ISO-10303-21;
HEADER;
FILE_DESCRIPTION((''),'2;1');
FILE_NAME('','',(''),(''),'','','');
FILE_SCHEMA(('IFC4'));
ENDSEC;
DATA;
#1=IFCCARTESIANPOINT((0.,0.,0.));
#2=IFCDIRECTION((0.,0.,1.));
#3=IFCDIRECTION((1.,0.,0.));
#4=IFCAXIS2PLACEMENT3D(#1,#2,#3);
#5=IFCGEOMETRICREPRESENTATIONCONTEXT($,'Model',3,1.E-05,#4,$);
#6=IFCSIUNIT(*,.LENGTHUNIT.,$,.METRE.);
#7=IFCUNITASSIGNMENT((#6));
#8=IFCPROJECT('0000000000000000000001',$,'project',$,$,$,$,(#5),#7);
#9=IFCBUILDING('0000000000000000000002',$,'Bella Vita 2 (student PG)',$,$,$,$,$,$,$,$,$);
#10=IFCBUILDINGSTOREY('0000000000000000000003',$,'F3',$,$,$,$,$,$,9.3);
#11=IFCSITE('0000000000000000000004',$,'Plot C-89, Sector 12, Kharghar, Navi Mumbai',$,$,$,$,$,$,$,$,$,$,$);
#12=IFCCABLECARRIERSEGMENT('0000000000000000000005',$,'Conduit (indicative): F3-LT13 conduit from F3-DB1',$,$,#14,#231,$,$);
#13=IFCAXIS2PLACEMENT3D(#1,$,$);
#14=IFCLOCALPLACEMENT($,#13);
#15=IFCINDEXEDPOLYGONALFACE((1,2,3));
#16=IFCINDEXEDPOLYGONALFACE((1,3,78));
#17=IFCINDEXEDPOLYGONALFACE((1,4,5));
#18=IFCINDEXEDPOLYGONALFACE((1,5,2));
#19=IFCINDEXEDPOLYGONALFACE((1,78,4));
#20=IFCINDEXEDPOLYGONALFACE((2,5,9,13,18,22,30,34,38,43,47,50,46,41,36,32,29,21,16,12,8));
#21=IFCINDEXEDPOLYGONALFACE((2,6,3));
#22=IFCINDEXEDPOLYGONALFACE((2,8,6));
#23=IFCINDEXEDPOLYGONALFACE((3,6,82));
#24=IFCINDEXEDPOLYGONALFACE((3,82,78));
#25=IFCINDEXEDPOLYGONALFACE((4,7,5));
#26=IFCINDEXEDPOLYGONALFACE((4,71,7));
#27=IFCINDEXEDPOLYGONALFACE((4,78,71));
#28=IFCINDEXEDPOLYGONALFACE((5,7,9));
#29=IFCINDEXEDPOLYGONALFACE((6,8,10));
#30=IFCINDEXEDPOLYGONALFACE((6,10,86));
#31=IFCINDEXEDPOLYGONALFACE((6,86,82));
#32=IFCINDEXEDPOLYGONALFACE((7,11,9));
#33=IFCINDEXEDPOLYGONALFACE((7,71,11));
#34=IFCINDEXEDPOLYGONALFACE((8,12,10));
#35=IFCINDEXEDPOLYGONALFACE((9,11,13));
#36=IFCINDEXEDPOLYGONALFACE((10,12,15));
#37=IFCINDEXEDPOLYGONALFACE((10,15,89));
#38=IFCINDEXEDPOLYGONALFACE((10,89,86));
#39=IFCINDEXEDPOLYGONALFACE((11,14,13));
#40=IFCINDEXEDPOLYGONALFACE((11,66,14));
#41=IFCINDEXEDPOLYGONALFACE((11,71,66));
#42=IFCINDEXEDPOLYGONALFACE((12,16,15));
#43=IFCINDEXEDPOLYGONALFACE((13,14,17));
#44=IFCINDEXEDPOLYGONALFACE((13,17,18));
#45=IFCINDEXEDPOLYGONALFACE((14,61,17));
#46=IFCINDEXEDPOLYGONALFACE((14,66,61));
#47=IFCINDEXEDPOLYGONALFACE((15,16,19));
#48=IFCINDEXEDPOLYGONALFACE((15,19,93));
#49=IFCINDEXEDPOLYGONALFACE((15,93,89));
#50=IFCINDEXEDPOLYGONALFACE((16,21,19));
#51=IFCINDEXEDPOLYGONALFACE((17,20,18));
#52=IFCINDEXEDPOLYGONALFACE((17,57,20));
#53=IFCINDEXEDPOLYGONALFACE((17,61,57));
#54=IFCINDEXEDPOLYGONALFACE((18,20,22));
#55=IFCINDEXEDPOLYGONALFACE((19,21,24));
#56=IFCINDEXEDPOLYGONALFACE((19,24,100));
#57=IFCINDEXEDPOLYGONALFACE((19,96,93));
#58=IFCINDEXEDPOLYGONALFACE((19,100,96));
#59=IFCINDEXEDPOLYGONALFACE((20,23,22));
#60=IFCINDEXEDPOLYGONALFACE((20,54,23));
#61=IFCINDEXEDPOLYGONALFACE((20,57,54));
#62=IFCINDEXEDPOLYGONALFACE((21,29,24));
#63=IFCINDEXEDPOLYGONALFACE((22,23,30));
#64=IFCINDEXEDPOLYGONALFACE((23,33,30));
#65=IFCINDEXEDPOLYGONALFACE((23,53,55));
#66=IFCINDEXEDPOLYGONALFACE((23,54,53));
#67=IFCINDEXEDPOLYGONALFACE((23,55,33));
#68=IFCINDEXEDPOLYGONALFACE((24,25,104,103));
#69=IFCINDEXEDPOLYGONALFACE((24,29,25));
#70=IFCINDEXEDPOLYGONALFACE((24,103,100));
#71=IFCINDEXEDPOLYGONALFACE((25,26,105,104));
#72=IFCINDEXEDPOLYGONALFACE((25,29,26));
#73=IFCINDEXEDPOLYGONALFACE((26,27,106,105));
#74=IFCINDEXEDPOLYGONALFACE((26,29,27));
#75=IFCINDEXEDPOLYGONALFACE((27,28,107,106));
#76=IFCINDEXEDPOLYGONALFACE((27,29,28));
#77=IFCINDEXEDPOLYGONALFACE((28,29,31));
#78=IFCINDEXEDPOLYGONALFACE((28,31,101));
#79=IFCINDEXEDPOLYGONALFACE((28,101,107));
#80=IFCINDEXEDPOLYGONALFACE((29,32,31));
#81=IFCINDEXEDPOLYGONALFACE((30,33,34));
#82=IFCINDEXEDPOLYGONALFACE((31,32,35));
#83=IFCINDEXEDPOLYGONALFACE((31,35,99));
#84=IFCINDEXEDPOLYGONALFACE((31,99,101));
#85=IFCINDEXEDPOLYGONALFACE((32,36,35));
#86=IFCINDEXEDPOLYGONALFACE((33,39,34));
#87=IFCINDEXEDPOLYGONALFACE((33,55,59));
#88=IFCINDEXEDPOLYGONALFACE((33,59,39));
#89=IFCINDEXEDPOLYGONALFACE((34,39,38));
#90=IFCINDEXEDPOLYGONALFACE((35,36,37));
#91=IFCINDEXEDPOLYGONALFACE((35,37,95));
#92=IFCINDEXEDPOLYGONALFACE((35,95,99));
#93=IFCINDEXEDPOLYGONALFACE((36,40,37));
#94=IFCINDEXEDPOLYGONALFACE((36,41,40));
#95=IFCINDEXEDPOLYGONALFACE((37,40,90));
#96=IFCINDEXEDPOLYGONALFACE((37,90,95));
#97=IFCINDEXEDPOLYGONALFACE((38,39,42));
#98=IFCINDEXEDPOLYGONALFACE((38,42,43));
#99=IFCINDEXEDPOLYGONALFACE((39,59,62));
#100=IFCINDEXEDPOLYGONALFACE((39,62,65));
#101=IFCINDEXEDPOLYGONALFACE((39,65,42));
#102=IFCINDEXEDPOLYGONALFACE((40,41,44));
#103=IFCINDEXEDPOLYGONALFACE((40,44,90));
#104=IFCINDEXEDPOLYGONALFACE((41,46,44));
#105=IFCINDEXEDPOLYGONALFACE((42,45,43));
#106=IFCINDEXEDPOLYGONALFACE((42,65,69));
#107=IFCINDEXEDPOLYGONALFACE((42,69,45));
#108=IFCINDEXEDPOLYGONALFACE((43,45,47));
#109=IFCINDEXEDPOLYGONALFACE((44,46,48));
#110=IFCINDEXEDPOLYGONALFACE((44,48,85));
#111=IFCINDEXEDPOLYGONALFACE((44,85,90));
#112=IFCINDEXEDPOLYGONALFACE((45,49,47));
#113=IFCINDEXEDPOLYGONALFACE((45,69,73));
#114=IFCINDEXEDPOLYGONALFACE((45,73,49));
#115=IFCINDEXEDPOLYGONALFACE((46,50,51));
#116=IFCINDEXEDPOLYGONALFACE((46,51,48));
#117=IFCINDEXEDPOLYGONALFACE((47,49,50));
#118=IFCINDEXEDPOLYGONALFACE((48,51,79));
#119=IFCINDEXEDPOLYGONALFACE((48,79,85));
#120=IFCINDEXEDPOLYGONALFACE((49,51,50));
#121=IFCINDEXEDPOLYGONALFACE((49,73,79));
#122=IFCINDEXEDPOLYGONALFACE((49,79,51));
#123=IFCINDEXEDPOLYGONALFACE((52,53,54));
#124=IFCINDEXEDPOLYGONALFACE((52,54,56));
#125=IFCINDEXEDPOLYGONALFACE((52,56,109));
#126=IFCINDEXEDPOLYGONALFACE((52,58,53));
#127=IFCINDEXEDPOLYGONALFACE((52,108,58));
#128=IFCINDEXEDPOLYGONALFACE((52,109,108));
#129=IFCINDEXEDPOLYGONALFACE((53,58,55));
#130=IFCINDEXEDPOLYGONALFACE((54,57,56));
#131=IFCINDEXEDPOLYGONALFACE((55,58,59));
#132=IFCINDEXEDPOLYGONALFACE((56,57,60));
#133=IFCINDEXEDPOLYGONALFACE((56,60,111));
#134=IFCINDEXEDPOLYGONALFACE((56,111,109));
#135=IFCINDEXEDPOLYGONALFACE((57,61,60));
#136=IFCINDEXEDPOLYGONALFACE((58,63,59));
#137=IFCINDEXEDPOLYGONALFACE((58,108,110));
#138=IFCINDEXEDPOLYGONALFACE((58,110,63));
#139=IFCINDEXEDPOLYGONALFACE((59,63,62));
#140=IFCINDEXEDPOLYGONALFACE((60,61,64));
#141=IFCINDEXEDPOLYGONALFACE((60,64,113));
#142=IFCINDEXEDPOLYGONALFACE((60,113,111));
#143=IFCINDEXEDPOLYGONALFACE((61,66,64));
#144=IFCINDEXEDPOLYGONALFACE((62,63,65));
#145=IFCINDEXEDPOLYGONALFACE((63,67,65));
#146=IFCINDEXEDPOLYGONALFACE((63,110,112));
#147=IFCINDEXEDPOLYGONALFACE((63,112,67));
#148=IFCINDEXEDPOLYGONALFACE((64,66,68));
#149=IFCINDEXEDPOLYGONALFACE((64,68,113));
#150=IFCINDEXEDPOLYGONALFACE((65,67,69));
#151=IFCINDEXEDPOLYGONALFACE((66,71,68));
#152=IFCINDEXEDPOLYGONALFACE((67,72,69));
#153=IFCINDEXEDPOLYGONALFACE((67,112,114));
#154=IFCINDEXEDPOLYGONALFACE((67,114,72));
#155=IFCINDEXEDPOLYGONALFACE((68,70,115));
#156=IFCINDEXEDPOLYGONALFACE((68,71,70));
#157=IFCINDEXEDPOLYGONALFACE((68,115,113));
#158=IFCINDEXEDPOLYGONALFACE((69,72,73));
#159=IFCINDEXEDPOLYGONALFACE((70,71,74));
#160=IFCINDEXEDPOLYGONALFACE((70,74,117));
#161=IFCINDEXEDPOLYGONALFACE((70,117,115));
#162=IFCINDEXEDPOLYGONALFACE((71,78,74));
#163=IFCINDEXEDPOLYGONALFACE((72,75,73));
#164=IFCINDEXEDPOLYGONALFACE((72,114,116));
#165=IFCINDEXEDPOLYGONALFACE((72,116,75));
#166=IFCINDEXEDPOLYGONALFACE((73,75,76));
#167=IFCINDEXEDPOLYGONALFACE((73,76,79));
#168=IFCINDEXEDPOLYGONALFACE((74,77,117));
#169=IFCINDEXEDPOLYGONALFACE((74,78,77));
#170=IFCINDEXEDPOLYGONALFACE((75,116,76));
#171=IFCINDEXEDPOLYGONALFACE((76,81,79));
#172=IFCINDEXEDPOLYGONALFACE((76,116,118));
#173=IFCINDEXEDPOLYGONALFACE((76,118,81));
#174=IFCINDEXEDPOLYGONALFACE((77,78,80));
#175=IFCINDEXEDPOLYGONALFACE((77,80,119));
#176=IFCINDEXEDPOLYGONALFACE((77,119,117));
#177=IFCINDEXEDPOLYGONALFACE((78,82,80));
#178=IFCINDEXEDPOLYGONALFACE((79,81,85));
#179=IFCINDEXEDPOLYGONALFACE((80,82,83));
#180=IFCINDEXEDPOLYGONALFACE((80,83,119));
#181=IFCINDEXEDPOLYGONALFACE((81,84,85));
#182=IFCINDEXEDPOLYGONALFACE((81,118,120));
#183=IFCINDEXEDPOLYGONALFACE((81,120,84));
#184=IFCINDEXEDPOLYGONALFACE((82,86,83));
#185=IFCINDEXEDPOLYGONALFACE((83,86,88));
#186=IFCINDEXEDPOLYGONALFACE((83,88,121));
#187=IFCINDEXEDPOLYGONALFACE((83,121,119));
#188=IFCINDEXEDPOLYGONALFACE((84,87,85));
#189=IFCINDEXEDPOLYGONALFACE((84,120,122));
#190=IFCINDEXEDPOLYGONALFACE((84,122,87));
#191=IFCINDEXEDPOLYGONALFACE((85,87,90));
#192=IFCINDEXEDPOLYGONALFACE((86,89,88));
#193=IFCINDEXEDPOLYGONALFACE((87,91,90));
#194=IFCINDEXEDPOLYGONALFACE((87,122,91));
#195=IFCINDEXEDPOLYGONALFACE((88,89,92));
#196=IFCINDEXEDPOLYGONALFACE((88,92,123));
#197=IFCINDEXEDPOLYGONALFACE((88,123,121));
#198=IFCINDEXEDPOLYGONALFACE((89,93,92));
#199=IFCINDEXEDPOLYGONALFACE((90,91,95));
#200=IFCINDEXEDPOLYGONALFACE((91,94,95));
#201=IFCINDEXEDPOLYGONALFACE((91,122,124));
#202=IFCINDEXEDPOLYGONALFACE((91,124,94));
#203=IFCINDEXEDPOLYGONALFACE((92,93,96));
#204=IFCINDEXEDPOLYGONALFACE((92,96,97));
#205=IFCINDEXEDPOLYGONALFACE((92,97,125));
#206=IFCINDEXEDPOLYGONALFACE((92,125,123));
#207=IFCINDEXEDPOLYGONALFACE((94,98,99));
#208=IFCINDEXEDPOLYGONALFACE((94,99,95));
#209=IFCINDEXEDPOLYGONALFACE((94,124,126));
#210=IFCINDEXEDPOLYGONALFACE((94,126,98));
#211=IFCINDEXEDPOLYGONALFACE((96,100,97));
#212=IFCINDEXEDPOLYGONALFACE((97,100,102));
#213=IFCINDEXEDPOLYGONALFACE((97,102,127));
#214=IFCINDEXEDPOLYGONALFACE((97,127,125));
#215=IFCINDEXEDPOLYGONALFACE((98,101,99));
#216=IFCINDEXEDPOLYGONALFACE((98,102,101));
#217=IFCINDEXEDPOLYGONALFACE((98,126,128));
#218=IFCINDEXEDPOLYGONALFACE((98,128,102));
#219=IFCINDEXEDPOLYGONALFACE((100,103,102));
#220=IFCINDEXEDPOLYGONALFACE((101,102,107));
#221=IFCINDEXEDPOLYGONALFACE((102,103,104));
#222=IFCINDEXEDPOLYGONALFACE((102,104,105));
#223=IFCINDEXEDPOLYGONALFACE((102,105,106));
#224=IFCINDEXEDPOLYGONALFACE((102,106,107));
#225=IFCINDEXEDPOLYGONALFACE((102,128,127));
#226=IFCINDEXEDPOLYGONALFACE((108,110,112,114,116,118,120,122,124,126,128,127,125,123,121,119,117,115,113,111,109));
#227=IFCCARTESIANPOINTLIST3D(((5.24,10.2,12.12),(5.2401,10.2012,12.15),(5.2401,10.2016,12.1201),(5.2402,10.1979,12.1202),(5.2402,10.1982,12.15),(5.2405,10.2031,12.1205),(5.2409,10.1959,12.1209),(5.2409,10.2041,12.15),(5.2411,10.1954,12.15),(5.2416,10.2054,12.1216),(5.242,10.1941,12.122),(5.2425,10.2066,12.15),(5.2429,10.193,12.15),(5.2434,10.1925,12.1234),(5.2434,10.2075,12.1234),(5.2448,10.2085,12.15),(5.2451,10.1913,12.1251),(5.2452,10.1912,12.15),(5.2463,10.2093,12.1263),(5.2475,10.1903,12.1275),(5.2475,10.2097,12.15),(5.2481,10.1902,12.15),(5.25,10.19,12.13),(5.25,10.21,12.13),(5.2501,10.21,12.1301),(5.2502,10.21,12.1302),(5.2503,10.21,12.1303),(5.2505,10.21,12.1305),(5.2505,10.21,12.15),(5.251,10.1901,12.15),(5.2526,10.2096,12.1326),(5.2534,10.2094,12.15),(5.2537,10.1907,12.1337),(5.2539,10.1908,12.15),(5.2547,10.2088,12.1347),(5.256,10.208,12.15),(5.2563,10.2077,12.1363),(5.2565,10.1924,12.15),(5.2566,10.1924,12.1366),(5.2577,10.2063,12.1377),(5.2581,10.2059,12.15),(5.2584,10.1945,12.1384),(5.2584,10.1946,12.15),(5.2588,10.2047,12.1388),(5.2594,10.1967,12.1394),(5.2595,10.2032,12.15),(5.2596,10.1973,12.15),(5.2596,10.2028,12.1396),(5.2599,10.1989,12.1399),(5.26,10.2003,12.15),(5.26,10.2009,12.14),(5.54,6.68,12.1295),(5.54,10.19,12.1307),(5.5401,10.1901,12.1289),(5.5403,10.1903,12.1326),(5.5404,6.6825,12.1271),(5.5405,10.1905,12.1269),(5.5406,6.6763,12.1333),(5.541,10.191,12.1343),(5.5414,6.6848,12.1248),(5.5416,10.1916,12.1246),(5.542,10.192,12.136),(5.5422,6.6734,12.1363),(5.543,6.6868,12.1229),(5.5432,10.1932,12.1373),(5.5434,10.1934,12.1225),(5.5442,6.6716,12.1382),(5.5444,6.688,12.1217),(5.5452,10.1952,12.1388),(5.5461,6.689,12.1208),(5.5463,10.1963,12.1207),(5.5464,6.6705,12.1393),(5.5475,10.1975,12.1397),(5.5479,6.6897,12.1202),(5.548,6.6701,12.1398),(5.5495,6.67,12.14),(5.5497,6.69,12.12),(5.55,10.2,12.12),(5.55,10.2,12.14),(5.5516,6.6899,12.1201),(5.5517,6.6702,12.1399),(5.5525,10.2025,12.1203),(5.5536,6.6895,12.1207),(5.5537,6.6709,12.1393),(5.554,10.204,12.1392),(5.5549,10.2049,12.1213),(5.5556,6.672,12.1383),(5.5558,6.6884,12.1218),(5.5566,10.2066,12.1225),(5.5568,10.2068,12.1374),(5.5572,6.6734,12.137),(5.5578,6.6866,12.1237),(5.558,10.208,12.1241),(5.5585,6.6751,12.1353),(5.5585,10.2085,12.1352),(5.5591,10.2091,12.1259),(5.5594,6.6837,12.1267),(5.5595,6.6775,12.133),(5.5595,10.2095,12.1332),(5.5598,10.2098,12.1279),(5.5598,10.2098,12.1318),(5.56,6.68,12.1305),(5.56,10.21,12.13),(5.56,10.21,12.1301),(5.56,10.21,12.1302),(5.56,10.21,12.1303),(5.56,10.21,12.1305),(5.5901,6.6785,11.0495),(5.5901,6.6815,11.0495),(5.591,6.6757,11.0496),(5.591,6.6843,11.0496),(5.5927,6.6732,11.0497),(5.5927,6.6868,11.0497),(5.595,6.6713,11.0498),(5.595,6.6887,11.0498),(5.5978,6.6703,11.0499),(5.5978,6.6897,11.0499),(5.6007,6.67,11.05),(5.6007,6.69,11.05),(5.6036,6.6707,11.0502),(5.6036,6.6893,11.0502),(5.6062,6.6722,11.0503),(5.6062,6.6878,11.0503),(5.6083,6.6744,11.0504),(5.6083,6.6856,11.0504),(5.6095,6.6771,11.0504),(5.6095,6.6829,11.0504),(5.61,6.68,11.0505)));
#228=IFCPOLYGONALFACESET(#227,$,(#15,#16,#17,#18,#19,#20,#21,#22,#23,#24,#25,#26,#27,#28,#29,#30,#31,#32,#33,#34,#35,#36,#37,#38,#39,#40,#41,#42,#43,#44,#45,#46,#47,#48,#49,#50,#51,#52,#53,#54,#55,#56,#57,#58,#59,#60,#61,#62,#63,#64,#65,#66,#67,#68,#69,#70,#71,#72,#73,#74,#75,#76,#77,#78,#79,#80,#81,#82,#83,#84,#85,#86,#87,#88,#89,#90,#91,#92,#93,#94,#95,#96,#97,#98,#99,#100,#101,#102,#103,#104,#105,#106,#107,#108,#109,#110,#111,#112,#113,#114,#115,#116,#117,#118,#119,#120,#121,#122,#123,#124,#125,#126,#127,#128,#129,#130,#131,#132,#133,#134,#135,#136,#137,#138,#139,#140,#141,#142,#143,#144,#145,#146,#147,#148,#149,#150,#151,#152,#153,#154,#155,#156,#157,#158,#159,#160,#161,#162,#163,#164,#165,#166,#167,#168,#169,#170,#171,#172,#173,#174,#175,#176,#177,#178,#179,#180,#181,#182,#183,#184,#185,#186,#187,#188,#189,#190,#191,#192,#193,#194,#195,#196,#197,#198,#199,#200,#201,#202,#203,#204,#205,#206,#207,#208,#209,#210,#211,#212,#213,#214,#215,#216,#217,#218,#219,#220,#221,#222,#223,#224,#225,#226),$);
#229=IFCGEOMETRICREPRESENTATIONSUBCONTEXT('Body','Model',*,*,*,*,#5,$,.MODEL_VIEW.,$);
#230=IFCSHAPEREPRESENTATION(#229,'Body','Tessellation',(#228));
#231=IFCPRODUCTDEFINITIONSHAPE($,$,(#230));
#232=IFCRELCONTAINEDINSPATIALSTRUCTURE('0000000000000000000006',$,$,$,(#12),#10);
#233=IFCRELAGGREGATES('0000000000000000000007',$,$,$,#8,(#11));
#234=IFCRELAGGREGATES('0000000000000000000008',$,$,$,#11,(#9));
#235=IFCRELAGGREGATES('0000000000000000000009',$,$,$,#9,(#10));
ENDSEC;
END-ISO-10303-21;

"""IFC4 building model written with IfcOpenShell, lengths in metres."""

from ifc_helpers import new_model, entity, si_unit, origin, origin_with_axes, place, context, subcontext, project, spatial, element, save


model = new_model("IFC4")

# Units and contexts
model_context = context("Model", 3, precision=1e-05, world=origin_with_axes())
body_context = subcontext(model_context, "Body", "Model", "MODEL_VIEW")
ifc_project = project(units=[si_unit("LENGTHUNIT", "METRE")], contexts=[model_context])

# Site, building, storey
site = spatial("IfcSite", under=ifc_project, Name="Plot C-89, Sector 12, Kharghar, Navi Mumbai")
building = spatial("IfcBuilding", under=site, Name="Bella Vita 2 (student PG)")
storey = spatial("IfcBuildingStorey", under=building, Name="F3", Elevation=9.3)

# Cable carrier segment
cable_carrier_segment_1_placement = place(None, origin())
element("IfcCableCarrierSegment", 1, at=cable_carrier_segment_1_placement, inside=storey, Name="Conduit (indicative): F3-LT13 conduit from F3-DB1", context=body_context, shape_type="AdvancedSweptSolid", body=[
    entity("IfcSweptDiskSolid", entity("IfcPolyline", [entity("IfcCartesianPoint", [5.6, 6.68, 11.05]), entity("IfcCartesianPoint", [5.55, 6.68, 12.13]), entity("IfcCartesianPoint", [5.55, 10.2, 12.13]), entity("IfcCartesianPoint", [5.25, 10.2, 12.13]), entity("IfcCartesianPoint", [5.25, 10.2, 12.15])]), 0.01),
])

save(model, "model.ifc")
